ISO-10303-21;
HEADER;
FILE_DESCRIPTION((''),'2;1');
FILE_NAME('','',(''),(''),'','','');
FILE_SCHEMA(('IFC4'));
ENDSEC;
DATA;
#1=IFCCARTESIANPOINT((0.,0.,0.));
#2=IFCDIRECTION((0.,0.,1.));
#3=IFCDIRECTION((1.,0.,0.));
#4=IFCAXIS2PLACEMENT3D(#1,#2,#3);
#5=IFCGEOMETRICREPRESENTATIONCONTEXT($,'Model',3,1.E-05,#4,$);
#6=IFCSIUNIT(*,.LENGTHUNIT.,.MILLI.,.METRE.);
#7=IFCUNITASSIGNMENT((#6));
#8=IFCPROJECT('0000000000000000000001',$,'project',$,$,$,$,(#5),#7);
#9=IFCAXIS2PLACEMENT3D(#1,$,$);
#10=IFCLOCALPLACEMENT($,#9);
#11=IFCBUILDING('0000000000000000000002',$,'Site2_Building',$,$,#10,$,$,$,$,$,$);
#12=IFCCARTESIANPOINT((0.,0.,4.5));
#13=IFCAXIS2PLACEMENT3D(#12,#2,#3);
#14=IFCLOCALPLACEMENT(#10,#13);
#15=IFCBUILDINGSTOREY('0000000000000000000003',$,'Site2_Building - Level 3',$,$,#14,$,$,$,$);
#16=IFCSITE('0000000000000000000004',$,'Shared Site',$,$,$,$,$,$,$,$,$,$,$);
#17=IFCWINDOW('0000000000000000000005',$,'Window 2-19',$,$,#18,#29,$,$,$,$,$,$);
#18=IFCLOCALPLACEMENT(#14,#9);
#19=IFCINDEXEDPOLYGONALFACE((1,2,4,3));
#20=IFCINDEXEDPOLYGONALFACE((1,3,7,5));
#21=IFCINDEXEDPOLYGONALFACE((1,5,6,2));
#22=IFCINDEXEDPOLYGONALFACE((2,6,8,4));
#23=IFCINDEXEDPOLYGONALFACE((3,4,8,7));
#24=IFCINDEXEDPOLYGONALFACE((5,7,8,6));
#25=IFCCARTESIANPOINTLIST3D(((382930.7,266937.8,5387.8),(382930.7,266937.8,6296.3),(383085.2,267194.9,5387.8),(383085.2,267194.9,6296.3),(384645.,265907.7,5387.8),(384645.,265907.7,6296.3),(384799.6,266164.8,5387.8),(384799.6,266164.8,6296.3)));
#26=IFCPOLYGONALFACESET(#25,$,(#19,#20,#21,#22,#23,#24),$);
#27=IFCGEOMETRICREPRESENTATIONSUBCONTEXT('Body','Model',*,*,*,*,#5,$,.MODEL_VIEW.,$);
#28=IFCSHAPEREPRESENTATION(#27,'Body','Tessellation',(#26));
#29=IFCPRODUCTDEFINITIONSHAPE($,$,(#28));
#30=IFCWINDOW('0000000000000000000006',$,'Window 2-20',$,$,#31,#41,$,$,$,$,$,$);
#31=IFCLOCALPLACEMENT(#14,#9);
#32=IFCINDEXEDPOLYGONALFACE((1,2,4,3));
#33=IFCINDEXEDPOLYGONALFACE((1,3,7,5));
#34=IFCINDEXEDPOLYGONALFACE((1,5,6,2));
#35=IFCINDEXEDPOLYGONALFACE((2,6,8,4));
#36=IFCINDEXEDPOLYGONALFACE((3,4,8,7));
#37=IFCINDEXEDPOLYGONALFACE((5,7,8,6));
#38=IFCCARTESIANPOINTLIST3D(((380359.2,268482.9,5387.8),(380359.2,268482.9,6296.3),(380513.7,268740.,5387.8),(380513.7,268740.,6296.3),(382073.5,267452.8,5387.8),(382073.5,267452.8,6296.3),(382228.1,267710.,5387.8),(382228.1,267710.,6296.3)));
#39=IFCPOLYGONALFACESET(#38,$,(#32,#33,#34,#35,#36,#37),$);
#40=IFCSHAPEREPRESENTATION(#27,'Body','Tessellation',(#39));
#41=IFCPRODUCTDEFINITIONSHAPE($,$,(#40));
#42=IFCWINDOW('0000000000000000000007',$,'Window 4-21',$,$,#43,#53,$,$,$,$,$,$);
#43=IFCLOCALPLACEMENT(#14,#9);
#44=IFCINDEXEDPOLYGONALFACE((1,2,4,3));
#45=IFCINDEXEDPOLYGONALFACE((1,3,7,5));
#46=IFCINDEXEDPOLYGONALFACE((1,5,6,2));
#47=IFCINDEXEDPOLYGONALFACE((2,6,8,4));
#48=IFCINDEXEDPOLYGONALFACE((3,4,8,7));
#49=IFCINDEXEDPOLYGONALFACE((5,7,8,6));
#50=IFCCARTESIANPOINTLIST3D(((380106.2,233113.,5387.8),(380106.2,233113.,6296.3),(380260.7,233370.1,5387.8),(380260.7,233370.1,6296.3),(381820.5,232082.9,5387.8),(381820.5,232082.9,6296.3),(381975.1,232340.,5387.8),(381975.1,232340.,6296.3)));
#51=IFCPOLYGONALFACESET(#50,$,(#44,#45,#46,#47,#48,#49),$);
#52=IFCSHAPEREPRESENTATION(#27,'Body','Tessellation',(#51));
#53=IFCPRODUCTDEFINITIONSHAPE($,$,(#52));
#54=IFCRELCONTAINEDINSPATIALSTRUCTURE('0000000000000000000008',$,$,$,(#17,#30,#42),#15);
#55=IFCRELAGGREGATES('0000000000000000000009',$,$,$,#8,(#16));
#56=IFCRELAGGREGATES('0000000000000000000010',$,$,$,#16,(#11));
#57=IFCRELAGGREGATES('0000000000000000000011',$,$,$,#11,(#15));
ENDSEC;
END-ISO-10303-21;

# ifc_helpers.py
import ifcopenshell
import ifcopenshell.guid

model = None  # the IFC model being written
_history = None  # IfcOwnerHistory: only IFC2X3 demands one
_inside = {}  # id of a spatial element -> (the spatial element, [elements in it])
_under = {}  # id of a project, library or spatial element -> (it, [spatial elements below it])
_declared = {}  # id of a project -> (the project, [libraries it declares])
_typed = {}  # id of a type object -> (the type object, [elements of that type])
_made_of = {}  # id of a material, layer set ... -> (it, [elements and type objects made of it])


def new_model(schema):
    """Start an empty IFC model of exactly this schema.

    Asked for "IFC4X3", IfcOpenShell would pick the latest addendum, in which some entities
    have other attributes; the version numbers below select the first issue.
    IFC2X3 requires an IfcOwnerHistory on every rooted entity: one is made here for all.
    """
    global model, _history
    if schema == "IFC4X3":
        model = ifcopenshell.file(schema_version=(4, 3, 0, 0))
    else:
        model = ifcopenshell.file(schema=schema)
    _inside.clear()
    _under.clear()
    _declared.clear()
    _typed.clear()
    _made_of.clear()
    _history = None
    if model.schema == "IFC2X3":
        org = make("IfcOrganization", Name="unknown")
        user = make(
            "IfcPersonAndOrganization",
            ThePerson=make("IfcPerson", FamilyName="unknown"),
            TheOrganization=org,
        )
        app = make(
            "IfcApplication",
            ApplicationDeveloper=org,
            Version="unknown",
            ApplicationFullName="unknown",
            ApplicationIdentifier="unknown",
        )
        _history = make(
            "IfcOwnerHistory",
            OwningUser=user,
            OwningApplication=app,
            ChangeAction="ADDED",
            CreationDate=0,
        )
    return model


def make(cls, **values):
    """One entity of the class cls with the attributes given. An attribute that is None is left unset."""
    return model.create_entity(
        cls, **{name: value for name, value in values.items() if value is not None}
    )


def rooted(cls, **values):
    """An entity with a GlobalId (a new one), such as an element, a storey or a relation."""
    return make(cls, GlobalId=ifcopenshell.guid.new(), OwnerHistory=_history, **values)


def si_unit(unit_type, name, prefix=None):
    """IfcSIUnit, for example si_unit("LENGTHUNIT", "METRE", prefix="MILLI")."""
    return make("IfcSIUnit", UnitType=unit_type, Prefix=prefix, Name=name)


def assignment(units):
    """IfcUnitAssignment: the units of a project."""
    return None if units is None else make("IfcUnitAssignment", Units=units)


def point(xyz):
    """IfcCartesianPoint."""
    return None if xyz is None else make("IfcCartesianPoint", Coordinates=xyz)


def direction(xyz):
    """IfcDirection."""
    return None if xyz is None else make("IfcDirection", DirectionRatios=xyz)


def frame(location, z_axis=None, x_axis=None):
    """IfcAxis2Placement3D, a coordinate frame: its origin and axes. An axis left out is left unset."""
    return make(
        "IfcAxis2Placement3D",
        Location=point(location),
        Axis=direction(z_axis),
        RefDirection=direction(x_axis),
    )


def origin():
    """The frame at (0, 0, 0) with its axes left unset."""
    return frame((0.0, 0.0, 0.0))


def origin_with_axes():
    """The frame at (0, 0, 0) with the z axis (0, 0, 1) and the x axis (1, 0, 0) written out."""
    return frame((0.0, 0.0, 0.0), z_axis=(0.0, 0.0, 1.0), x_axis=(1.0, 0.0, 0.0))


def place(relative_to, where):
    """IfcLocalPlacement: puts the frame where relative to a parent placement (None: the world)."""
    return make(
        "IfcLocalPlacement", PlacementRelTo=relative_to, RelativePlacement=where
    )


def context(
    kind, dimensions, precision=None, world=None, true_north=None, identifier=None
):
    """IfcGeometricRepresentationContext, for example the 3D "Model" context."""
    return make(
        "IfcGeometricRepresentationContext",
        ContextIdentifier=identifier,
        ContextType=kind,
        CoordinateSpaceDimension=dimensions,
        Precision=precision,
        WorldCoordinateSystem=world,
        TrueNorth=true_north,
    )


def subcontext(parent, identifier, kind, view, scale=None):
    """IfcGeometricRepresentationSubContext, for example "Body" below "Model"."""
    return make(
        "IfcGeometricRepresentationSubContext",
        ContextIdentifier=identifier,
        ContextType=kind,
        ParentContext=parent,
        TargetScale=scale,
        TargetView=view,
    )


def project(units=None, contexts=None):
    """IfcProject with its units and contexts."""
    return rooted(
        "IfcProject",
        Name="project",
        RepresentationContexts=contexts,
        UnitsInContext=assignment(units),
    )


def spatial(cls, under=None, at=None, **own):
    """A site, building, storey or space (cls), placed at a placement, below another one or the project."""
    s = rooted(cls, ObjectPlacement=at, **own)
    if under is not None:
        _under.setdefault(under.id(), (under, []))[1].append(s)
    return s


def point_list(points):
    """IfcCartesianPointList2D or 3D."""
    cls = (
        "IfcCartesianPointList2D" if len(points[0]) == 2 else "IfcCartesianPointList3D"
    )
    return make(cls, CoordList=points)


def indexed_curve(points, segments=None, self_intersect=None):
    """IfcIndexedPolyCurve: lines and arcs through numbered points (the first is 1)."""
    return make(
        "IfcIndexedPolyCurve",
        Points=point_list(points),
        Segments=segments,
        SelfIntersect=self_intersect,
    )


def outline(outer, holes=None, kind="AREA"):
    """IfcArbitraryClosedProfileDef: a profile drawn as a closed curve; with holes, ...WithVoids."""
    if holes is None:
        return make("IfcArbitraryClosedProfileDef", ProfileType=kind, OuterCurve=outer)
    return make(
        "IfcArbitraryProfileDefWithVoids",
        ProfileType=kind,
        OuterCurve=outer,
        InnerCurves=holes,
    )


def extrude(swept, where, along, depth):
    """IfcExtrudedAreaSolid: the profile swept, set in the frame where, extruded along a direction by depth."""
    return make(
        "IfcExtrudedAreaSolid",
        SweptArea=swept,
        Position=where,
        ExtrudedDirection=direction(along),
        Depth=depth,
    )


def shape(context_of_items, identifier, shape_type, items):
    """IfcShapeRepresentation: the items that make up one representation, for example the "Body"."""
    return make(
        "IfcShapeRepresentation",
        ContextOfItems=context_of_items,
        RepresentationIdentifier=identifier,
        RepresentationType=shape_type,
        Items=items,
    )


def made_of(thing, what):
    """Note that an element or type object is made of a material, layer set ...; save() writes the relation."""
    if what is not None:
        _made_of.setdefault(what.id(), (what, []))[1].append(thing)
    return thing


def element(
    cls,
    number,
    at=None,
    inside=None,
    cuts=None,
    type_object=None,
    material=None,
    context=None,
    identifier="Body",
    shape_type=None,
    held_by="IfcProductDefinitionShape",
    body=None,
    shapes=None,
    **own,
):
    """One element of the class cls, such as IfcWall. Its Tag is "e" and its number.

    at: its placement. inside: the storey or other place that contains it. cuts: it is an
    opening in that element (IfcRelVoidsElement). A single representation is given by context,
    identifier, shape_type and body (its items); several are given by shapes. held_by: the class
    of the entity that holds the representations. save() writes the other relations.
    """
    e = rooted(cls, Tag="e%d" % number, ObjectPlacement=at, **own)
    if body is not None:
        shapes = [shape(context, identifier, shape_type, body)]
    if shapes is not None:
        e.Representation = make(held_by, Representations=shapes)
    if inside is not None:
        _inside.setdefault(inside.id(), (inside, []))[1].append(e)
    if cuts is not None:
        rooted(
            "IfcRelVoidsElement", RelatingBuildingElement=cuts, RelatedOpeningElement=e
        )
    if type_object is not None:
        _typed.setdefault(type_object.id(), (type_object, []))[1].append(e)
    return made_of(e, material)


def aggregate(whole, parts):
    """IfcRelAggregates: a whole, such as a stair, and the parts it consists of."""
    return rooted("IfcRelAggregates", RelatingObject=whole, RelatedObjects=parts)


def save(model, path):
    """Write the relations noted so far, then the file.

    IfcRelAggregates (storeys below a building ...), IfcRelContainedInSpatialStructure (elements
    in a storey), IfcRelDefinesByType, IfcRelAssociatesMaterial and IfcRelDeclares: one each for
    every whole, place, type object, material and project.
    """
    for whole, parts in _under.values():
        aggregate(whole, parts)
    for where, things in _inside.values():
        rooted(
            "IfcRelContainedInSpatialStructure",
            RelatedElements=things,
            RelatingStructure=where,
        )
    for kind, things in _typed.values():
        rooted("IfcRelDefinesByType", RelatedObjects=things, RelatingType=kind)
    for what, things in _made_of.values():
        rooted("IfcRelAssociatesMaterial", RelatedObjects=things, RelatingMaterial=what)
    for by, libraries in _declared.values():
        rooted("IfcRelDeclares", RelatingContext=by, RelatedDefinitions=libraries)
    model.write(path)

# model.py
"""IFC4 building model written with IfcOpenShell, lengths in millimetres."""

from ifc_helpers import new_model, si_unit, frame, origin, origin_with_axes, place, context, subcontext, project, spatial, indexed_curve, outline, extrude, element, save


model = new_model("IFC4")

# Units and contexts
model_context = context("Model", 3, precision=1e-05, world=origin_with_axes())
body_context = subcontext(model_context, "Body", "Model", "MODEL_VIEW")
ifc_project = project(units=[si_unit("LENGTHUNIT", "METRE", prefix="MILLI")], contexts=[model_context])

# Site, building, storey
site = spatial("IfcSite", under=ifc_project, Name="Shared Site")
building_placement = place(None, origin())
building = spatial("IfcBuilding", under=site, at=building_placement, Name="Site2_Building")
storey_placement = place(building_placement, frame((0.0, 0.0, 4.5), z_axis=(0.0, 0.0, 1.0), x_axis=(1.0, 0.0, 0.0)))
storey = spatial("IfcBuildingStorey", under=building, at=storey_placement, Name="Site2_Building - Level 3")

# Windows
for number, where, z_axis, x_axis, name in (
    (1, (384799.6, 266164.8, 5387.8), (0.0, 0.0, 1.0), (-0.857167, 0.515038, 0.0), "Window 2-19"),
    (2, (382228.1, 267710.0, 5387.8), (0.0, 0.0, 1.0), (-0.857167, 0.515038, 0.0), "Window 2-20"),
    (3, (380106.2, 233113.0, 5387.8), (0.0, 0.0, 1.0), (0.857167, -0.515038, 0.0), "Window 4-21"),
):
    element("IfcWindow", number, at=place(storey_placement, frame(where, z_axis=z_axis, x_axis=x_axis)), inside=storey, Name=name, context=body_context, shape_type="SweptSolid", body=[
        extrude(outline(indexed_curve([(0.0, 0.0), (0.0, 300.0), (2000.0, 300.0), (2000.0, 0.0), (0.0, 0.0)], self_intersect=False)), origin_with_axes(), (0.0, 0.0, 1.0), 908.6),
    ])

save(model, "model.ifc")
